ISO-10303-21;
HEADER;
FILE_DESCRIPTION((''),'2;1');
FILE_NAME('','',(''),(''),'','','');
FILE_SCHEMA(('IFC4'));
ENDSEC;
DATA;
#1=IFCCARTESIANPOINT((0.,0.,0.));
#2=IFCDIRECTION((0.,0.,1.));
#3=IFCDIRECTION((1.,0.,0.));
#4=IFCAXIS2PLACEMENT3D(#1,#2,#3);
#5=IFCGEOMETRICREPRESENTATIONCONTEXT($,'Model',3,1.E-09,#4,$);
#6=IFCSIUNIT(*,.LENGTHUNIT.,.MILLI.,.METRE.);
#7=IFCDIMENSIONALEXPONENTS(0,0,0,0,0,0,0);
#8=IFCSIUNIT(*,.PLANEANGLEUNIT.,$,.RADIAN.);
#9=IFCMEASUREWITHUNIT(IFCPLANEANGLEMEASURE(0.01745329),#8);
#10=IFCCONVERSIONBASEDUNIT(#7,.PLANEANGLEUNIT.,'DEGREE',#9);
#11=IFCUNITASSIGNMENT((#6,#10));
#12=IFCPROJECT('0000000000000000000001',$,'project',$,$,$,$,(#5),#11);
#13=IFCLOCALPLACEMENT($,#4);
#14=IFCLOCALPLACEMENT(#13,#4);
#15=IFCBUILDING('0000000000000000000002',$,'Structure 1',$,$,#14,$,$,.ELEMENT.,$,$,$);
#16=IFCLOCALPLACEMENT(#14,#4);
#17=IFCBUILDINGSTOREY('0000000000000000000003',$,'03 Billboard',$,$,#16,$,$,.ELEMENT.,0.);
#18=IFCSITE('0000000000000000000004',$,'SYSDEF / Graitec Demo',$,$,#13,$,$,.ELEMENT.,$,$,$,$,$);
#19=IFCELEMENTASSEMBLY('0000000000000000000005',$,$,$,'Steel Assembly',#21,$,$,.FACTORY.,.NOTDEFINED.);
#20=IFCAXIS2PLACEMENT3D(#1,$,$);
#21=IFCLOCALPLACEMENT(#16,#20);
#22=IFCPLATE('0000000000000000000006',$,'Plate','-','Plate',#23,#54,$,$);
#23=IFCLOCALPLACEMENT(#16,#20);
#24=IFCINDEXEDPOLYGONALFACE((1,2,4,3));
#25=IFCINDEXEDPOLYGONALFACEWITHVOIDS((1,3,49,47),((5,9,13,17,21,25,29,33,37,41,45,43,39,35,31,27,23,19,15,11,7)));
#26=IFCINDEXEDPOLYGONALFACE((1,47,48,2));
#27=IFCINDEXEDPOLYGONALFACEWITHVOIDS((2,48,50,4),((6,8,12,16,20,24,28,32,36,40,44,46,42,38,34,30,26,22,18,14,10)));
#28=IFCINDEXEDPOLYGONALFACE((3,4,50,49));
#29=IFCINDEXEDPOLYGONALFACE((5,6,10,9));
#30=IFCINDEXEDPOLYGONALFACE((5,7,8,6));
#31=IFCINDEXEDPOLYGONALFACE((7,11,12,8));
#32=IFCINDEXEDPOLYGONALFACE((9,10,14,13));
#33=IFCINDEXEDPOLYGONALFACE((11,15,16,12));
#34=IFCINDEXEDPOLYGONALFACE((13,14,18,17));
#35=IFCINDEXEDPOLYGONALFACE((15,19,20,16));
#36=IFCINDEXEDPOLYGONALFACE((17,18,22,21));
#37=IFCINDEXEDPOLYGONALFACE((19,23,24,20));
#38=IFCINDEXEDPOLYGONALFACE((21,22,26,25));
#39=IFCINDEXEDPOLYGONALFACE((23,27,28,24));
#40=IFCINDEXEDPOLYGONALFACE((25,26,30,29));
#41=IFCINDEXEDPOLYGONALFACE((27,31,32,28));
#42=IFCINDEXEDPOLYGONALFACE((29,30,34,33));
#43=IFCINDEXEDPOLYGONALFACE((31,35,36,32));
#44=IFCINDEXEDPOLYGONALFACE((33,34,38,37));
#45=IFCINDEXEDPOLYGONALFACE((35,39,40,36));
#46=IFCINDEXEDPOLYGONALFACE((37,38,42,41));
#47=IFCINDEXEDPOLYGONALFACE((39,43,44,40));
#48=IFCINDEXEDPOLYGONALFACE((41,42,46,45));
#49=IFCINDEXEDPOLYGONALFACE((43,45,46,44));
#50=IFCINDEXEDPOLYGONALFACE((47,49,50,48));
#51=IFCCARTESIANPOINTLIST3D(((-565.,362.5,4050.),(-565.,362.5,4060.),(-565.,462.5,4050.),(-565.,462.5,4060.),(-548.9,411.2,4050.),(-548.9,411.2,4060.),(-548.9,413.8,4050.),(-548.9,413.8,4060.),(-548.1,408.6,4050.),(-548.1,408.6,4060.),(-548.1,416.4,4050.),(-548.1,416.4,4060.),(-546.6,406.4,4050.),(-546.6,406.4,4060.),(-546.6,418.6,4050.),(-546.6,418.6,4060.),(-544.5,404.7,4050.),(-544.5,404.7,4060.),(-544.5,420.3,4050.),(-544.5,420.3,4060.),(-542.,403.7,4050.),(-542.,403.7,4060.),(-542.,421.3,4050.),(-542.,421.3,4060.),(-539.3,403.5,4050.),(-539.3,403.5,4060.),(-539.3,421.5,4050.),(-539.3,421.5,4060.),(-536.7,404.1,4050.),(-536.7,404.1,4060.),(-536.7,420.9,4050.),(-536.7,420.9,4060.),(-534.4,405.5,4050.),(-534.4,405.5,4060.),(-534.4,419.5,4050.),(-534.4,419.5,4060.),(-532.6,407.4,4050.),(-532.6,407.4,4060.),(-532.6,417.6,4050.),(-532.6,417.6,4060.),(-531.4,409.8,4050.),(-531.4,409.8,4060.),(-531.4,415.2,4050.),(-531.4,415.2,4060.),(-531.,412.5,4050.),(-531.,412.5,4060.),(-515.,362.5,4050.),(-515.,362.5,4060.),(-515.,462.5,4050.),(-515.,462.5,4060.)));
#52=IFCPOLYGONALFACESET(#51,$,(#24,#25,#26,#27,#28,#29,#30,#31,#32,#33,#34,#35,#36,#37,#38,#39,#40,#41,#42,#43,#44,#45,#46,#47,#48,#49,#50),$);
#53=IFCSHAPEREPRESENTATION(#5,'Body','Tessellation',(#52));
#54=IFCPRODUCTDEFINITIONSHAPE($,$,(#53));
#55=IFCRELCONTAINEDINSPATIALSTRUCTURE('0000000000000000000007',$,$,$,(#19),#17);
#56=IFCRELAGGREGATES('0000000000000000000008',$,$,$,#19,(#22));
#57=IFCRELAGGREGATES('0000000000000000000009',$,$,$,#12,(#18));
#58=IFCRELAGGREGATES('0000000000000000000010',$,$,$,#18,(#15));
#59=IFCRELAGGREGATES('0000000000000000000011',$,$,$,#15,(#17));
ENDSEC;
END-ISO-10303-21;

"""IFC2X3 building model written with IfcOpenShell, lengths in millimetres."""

from ifc_helpers import new_model, entity, si_unit, converted_unit, frame, frame_2d, origin, origin_with_axes, place, context, project, spatial, polyline, circle, outline, extrude, element, aggregate, save


model = new_model("IFC2X3")

# Units and contexts
model_context = context("Model", 3, precision=1e-09, world=origin_with_axes())
ifc_project = project(units=[si_unit("LENGTHUNIT", "METRE", prefix="MILLI"), converted_unit("PLANEANGLEUNIT", "DEGREE", entity("IfcPlaneAngleMeasure", 0.01745329), si_unit("PLANEANGLEUNIT", "RADIAN"), dimensions=[0, 0, 0, 0, 0, 0, 0])], contexts=[model_context])

# Site, building, storey
site_placement = place(None, origin_with_axes())
site = spatial("IfcSite", under=ifc_project, at=site_placement, Name="SYSDEF / Graitec Demo", CompositionType="ELEMENT")
building_placement = place(site_placement, origin_with_axes())
building = spatial("IfcBuilding", under=site, at=building_placement, Name="Structure 1", CompositionType="ELEMENT")
storey_placement = place(building_placement, origin_with_axes())
storey = spatial("IfcBuildingStorey", under=building, at=storey_placement, Name="03 Billboard", CompositionType="ELEMENT", Elevation=0.0)

# Element assembly, plate, opening
assembly_1_placement = place(None, frame((-540.0, 412.5, 4060.0), z_axis=(0.0, 0.0, -1.0), x_axis=(1.0, 0.0, 0.0)))
assembly_1 = element("IfcElementAssembly", 1, at=assembly_1_placement, inside=storey, ObjectType="Steel Assembly", AssemblyPlace="FACTORY", PredefinedType="NOTDEFINED")
plate_placement = place(assembly_1_placement, origin_with_axes())
plate = element("IfcPlate", 2, at=plate_placement, Name="Plate", Description="-", ObjectType="Plate", context=model_context, shape_type="SweptSolid", body=[
    extrude(outline(polyline([(-25.0, -50.0), (25.0, -50.0), (25.0, 50.0), (-25.0, 50.0), (-25.0, -50.0)])), origin_with_axes(), (0.0, 0.0, 1.0), 10.0),
])
opening_1_placement = place(plate_placement, frame((-9.0, 0.0, 10.5), z_axis=(0.0, 0.0, 1.0), x_axis=(1.0, 0.0, 0.0)))
element("IfcOpeningElement", 3, at=opening_1_placement, cuts=plate, ObjectType="Opening", context=model_context, shape_type="SweptSolid", body=[
    extrude(circle(Radius=9.0, at=frame_2d((9.0, 0.0), x_axis=(1.0, 0.0))), origin(), (0.0, 0.0, -1.0), 11.0),
])
aggregate(assembly_1, [plate])

save(model, "model.ifc")
